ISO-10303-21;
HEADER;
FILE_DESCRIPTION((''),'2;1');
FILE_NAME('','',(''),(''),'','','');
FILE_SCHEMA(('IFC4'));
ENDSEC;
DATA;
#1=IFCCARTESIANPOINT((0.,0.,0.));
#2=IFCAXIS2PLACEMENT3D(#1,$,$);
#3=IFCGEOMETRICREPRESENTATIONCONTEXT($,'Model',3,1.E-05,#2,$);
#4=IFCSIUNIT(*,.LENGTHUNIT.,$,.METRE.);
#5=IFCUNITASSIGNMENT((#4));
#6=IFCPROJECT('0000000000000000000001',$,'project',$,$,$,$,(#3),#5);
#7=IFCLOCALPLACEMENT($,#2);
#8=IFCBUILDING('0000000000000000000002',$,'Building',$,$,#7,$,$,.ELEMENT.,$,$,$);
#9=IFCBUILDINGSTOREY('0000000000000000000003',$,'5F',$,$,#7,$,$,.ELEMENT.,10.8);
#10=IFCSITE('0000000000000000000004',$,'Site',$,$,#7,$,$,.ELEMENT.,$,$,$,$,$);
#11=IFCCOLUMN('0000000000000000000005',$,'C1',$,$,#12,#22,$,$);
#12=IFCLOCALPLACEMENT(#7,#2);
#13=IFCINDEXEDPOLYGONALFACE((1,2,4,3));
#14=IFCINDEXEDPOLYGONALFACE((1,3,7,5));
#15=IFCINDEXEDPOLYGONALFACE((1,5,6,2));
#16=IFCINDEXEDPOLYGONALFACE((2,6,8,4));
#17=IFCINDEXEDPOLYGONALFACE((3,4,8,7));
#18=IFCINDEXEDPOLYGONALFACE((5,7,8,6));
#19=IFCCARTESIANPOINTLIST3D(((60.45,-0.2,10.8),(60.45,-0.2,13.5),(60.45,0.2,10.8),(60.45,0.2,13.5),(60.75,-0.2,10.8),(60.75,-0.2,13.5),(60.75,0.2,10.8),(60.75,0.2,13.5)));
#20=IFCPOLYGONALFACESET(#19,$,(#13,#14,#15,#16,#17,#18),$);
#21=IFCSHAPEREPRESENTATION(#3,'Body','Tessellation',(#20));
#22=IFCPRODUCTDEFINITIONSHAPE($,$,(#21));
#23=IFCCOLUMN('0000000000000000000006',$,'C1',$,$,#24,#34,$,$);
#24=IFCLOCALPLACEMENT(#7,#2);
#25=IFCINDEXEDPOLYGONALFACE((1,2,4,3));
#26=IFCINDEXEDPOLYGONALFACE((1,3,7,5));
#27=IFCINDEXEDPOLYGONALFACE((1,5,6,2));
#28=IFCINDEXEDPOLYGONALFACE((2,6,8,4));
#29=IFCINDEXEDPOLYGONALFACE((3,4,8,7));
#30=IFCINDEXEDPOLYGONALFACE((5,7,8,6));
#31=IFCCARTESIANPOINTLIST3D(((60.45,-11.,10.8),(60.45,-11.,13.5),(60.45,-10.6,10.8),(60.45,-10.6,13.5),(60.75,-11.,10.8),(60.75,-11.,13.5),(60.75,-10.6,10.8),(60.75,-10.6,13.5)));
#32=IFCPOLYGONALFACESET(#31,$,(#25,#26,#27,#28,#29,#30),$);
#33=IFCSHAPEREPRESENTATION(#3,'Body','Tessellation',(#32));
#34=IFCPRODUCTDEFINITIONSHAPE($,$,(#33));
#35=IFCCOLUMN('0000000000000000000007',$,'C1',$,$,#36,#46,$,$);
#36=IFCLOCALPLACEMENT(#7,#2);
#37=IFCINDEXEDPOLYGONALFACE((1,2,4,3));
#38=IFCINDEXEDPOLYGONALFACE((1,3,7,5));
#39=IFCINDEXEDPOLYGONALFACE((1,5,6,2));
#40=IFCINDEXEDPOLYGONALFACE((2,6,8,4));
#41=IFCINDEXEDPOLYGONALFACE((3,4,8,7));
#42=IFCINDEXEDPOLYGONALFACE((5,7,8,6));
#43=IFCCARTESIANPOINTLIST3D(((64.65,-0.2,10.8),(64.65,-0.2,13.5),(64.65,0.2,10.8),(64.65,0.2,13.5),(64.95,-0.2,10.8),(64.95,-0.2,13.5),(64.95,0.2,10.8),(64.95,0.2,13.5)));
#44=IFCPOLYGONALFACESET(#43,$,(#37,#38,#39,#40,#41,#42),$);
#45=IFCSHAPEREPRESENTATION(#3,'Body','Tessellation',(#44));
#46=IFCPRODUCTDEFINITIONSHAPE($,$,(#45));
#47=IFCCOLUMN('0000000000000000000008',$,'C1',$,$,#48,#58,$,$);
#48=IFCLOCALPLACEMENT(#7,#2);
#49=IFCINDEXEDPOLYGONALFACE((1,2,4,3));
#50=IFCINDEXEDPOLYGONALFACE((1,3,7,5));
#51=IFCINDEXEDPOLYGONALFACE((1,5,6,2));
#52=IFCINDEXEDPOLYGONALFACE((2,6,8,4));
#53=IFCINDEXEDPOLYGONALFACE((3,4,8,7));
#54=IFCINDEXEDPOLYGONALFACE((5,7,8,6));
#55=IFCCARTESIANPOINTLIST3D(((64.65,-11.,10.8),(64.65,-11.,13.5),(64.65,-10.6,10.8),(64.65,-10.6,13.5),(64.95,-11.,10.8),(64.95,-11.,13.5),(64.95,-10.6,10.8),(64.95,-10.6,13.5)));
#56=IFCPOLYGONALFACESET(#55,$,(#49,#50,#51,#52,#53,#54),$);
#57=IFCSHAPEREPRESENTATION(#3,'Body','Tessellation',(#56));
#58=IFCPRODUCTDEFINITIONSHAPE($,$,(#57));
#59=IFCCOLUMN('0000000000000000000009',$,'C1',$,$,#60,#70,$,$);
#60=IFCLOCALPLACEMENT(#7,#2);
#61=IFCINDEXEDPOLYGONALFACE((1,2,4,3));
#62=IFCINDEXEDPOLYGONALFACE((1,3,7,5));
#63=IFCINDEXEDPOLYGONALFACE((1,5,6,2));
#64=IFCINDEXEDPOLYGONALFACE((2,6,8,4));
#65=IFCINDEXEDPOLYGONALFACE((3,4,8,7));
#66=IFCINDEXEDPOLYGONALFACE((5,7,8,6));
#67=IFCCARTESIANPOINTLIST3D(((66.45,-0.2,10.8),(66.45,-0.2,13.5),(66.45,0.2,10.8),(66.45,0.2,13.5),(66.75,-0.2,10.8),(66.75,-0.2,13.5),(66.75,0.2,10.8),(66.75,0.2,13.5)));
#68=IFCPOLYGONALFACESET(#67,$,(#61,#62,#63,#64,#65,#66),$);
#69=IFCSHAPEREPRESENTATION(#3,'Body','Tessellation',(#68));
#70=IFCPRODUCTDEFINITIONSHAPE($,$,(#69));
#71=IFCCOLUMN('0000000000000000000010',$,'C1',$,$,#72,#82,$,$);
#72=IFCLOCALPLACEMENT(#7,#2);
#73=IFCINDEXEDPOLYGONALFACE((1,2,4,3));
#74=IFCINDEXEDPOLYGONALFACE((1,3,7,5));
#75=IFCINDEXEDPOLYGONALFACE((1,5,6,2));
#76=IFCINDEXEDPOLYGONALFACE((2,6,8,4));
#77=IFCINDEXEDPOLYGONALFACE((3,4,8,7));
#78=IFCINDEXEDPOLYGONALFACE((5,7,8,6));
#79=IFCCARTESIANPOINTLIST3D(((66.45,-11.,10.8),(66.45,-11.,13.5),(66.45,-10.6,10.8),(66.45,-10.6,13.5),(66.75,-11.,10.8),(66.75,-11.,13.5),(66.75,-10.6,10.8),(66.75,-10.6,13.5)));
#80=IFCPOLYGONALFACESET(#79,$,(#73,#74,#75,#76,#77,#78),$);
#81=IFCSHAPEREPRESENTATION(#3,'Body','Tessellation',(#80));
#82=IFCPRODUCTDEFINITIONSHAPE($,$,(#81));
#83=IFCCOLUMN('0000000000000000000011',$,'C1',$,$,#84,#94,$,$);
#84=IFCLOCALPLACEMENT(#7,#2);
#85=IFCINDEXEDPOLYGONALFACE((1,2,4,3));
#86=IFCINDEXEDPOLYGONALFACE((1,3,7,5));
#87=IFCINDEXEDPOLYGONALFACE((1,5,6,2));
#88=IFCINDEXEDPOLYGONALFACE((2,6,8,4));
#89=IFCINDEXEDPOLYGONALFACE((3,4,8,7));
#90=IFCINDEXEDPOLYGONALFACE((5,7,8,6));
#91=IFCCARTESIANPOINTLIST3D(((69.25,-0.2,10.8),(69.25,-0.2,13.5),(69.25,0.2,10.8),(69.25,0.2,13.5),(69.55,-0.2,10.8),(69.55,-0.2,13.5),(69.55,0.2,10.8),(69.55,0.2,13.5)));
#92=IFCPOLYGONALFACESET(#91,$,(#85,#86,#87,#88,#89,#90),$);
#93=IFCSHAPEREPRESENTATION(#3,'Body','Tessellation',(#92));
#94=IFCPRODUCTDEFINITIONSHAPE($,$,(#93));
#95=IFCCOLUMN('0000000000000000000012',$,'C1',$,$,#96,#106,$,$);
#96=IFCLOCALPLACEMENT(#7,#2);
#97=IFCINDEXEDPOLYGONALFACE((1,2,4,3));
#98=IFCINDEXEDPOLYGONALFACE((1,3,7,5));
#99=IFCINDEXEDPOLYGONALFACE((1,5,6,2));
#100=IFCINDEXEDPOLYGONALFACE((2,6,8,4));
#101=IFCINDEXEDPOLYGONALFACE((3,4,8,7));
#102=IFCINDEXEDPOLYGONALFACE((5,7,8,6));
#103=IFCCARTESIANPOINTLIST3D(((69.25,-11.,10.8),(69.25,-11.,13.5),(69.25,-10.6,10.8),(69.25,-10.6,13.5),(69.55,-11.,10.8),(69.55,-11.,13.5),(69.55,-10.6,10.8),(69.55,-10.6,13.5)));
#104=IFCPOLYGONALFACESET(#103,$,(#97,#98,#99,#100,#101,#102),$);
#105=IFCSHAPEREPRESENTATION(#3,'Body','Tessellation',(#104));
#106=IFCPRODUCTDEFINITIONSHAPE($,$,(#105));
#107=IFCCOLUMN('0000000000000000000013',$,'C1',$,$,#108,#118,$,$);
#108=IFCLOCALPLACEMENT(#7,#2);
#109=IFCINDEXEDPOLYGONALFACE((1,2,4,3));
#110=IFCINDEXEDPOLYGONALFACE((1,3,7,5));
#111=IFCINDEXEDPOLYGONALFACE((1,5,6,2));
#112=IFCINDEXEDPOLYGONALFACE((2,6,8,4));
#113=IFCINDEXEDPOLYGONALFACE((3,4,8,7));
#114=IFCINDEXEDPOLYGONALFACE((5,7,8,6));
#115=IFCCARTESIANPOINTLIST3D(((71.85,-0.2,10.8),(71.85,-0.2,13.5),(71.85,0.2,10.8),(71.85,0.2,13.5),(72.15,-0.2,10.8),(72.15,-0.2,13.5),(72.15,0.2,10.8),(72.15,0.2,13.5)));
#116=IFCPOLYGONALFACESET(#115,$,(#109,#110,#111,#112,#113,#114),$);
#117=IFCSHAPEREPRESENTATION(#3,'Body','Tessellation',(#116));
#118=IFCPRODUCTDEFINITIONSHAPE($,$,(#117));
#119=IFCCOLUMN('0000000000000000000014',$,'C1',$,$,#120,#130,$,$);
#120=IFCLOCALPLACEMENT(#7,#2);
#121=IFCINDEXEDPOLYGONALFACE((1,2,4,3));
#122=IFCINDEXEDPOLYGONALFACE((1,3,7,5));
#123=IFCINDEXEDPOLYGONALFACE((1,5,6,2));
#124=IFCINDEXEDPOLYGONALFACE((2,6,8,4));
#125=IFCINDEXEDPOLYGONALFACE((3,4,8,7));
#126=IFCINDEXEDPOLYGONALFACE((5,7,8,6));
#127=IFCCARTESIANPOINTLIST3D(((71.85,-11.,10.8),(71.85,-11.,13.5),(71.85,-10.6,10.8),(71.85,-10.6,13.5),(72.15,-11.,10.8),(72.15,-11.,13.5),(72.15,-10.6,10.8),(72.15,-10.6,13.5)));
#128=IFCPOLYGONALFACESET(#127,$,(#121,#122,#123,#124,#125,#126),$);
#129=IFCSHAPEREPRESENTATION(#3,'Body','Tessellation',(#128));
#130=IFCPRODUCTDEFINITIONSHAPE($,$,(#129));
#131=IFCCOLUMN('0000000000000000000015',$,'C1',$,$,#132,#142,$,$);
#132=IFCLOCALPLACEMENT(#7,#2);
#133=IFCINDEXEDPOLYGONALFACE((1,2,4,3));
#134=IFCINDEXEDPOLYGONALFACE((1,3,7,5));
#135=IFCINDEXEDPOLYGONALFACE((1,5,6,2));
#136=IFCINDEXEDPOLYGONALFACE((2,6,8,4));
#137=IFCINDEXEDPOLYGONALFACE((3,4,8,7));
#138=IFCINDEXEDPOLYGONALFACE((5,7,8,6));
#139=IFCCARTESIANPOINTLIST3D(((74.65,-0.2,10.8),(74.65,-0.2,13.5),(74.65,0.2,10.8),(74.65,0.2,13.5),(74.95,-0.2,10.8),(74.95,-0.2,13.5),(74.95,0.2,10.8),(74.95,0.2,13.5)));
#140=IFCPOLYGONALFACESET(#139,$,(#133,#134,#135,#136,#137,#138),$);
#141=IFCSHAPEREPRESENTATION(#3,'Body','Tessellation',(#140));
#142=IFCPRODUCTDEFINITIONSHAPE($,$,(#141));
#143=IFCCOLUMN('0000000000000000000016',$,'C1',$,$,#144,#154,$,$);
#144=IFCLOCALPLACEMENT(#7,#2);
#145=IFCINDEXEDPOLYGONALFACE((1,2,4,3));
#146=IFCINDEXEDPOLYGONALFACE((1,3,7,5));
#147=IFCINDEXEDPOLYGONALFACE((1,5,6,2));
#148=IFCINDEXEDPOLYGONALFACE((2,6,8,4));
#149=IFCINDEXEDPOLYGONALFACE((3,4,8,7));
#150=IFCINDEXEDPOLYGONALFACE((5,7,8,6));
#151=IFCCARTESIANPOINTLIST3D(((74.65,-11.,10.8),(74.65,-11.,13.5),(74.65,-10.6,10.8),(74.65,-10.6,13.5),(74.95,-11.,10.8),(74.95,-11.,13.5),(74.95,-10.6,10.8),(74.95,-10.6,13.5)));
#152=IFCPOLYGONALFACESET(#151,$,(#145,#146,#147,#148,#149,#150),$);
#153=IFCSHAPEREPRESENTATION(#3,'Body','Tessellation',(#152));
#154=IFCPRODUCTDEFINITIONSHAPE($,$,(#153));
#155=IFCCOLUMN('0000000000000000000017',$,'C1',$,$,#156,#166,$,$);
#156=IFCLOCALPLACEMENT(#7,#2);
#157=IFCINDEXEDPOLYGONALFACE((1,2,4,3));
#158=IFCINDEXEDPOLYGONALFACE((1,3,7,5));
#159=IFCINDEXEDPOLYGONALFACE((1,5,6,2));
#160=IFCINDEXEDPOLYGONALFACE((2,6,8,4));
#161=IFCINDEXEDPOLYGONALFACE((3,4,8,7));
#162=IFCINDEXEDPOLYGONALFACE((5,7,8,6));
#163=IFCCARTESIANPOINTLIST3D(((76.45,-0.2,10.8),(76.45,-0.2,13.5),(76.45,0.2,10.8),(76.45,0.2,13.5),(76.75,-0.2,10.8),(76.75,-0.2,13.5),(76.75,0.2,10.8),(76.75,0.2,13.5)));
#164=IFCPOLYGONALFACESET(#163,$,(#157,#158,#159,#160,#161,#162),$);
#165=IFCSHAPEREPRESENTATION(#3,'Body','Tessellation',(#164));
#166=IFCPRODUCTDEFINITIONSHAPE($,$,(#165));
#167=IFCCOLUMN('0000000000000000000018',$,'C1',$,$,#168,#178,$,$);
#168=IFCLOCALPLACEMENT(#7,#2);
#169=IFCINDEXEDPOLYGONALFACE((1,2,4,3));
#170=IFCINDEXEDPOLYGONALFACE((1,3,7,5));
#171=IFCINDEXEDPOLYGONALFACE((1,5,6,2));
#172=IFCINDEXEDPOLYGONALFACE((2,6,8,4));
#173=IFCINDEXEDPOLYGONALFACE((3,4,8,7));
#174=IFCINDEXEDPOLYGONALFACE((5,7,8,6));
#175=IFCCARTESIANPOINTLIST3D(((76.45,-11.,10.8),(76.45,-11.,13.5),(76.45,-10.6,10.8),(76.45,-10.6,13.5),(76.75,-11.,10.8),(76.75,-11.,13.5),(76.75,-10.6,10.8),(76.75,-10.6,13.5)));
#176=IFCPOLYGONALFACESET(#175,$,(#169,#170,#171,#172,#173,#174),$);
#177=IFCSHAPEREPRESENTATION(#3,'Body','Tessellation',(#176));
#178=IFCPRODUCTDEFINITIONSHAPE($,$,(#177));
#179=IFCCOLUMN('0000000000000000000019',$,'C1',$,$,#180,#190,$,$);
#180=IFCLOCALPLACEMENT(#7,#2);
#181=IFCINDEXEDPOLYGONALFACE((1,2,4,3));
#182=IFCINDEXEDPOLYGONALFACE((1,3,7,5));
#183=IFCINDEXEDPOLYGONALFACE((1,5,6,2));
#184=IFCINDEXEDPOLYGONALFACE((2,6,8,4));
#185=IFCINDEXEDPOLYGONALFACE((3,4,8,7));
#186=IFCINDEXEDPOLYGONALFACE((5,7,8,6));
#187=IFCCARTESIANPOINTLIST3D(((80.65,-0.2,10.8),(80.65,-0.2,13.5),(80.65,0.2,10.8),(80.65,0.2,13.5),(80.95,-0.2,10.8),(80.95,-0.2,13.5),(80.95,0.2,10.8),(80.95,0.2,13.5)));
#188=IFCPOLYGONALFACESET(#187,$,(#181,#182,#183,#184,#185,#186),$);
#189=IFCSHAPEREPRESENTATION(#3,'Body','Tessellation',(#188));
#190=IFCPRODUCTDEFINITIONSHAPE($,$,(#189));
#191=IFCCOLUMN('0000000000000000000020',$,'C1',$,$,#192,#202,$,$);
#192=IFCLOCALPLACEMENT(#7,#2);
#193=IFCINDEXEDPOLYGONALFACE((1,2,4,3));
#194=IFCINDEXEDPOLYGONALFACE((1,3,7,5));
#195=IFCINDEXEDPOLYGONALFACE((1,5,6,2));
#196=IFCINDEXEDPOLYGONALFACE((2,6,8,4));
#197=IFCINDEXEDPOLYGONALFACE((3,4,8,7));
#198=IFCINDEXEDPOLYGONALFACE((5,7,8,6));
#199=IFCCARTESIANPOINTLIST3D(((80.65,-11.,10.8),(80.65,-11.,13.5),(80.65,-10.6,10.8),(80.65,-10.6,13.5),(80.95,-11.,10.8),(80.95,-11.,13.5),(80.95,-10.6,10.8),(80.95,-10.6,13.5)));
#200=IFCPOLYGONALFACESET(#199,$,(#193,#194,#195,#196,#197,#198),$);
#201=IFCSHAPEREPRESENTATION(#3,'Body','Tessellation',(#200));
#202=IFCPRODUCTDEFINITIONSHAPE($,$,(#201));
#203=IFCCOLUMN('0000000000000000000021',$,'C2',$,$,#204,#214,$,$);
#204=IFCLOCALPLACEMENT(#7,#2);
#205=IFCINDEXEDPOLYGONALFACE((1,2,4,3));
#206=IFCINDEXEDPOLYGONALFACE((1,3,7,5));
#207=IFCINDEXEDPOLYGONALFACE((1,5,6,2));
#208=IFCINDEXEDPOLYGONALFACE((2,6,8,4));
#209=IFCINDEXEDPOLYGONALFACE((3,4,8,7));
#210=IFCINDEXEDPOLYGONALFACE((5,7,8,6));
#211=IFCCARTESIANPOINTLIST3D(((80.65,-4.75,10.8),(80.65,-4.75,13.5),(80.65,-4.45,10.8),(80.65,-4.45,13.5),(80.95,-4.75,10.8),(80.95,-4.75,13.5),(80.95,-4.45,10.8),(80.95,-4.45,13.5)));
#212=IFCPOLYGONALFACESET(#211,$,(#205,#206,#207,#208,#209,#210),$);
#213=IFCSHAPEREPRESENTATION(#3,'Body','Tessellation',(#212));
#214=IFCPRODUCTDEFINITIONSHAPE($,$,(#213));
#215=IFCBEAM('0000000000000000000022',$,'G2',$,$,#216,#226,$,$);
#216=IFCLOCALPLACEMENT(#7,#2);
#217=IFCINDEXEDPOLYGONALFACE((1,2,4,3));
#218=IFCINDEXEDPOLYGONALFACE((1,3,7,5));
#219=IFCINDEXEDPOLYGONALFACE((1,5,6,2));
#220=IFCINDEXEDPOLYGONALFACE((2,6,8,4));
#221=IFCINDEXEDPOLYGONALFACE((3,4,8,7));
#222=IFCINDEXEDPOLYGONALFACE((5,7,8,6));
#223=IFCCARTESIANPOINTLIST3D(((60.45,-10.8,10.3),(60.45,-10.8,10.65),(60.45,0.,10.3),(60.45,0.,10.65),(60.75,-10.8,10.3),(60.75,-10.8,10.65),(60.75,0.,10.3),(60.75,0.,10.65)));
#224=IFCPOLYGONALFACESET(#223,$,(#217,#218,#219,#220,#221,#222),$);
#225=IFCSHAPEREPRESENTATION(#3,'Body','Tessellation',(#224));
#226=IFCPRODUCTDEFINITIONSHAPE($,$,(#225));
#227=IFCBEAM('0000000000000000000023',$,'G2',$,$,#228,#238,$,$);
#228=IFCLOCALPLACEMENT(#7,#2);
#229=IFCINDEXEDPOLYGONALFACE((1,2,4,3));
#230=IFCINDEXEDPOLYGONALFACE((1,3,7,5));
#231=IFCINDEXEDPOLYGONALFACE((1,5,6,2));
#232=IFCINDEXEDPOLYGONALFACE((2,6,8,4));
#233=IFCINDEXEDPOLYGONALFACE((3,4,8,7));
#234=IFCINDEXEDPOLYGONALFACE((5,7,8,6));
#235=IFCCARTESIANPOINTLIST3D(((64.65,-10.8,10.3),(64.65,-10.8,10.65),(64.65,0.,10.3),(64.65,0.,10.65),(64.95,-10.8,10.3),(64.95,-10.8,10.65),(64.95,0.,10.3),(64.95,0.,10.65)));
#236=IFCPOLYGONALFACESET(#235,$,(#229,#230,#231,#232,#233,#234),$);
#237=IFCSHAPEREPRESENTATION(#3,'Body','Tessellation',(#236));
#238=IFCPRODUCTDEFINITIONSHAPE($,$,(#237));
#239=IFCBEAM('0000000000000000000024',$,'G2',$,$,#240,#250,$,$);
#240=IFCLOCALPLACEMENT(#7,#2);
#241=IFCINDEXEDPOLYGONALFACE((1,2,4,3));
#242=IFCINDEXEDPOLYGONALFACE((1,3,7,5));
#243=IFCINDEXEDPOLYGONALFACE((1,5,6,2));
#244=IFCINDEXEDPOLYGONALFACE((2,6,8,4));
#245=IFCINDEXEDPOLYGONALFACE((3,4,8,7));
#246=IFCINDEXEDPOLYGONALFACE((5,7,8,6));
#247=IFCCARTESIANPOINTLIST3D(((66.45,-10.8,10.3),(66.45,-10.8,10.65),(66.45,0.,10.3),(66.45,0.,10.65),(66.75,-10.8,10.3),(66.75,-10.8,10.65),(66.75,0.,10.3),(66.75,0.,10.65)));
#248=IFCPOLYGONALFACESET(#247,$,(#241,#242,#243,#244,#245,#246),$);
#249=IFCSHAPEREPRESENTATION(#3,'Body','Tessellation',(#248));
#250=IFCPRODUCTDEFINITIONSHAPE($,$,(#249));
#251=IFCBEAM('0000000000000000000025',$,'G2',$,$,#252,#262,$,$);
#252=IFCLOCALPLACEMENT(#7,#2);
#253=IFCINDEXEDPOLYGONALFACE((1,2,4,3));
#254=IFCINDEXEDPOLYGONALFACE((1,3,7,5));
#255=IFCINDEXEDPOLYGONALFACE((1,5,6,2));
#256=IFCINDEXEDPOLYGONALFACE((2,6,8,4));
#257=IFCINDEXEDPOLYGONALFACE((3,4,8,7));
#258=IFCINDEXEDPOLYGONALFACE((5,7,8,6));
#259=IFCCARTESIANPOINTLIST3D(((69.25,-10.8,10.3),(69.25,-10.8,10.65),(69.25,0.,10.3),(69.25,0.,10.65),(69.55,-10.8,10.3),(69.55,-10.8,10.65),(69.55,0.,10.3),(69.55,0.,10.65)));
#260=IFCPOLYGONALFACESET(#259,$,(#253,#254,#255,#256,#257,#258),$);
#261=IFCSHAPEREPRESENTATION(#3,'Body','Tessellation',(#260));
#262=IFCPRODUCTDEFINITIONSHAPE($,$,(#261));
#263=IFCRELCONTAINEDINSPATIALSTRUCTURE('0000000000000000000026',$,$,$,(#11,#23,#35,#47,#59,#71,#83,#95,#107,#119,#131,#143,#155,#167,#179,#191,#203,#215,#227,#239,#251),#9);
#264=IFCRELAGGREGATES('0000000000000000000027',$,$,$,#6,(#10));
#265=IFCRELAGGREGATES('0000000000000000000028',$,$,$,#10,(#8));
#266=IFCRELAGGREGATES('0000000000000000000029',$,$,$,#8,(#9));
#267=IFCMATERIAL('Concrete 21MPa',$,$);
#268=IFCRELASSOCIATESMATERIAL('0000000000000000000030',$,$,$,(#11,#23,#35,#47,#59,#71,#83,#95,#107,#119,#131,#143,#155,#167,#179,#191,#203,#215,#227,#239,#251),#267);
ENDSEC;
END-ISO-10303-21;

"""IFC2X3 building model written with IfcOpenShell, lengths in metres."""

from ifc_helpers import new_model, si_unit, frame, origin, origin_2d, place, context, project, spatial, rectangle, extrude, material, element, save


model = new_model("IFC2X3")

# Units and contexts
model_context = context("Model", 3, precision=1e-05, world=origin())
ifc_project = project(units=[si_unit("LENGTHUNIT", "METRE")], contexts=[model_context])

# Site, building, storey
placement = place(None, origin())
site = spatial("IfcSite", under=ifc_project, at=placement, Name="Site", CompositionType="ELEMENT")
building = spatial("IfcBuilding", under=site, at=placement, Name="Building", CompositionType="ELEMENT")
storey = spatial("IfcBuildingStorey", under=building, at=placement, Name="5F", CompositionType="ELEMENT", Elevation=10.8)

# Columns
ifc_material = material(Name="Concrete 21MPa")
for number, where, name in (
    (1, (60.6, 0.0, 10.8), "C1"),
    (2, (60.6, -10.8, 10.8), "C1"),
    (3, (64.8, 0.0, 10.8), "C1"),
    (4, (64.8, -10.8, 10.8), "C1"),
    (5, (66.6, 0.0, 10.8), "C1"),
    (6, (66.6, -10.8, 10.8), "C1"),
    (7, (69.4, 0.0, 10.8), "C1"),
    (8, (69.4, -10.8, 10.8), "C1"),
    (9, (72.0, 0.0, 10.8), "C1"),
    (10, (72.0, -10.8, 10.8), "C1"),
    (11, (74.8, 0.0, 10.8), "C1"),
    (12, (74.8, -10.8, 10.8), "C1"),
    (13, (76.6, 0.0, 10.8), "C1"),
    (14, (76.6, -10.8, 10.8), "C1"),
    (15, (80.8, 0.0, 10.8), "C1"),
    (16, (80.8, -10.8, 10.8), "C1"),
):
    element("IfcColumn", number, at=place(None, frame(where)), inside=storey, material=ifc_material, Name=name, context=model_context, shape_type="SweptSolid", body=[
        extrude(rectangle(XDim=0.3, YDim=0.4, at=origin_2d()), origin(), (0.0, 0.0, 1.0), 2.7),
    ])
column_placement = place(None, frame((80.8, -4.6, 10.8)))
element("IfcColumn", 17, at=column_placement, inside=storey, material=ifc_material, Name="C2", context=model_context, shape_type="SweptSolid", body=[
    extrude(rectangle(XDim=0.3, YDim=0.3, at=origin_2d()), origin(), (0.0, 0.0, 1.0), 2.7),
])

# Beams
for number, where, name in (
    (18, (60.6, -5.4, 10.3), "G2"),
    (19, (64.8, -5.4, 10.3), "G2"),
    (20, (66.6, -5.4, 10.3), "G2"),
    (21, (69.4, -5.4, 10.3), "G2"),
):
    element("IfcBeam", number, at=place(None, frame(where)), inside=storey, material=ifc_material, Name=name, context=model_context, shape_type="SweptSolid", body=[
        extrude(rectangle(XDim=0.3, YDim=10.8, at=origin_2d()), origin(), (0.0, 0.0, 1.0), 0.35),
    ])

save(model, "model.ifc")
